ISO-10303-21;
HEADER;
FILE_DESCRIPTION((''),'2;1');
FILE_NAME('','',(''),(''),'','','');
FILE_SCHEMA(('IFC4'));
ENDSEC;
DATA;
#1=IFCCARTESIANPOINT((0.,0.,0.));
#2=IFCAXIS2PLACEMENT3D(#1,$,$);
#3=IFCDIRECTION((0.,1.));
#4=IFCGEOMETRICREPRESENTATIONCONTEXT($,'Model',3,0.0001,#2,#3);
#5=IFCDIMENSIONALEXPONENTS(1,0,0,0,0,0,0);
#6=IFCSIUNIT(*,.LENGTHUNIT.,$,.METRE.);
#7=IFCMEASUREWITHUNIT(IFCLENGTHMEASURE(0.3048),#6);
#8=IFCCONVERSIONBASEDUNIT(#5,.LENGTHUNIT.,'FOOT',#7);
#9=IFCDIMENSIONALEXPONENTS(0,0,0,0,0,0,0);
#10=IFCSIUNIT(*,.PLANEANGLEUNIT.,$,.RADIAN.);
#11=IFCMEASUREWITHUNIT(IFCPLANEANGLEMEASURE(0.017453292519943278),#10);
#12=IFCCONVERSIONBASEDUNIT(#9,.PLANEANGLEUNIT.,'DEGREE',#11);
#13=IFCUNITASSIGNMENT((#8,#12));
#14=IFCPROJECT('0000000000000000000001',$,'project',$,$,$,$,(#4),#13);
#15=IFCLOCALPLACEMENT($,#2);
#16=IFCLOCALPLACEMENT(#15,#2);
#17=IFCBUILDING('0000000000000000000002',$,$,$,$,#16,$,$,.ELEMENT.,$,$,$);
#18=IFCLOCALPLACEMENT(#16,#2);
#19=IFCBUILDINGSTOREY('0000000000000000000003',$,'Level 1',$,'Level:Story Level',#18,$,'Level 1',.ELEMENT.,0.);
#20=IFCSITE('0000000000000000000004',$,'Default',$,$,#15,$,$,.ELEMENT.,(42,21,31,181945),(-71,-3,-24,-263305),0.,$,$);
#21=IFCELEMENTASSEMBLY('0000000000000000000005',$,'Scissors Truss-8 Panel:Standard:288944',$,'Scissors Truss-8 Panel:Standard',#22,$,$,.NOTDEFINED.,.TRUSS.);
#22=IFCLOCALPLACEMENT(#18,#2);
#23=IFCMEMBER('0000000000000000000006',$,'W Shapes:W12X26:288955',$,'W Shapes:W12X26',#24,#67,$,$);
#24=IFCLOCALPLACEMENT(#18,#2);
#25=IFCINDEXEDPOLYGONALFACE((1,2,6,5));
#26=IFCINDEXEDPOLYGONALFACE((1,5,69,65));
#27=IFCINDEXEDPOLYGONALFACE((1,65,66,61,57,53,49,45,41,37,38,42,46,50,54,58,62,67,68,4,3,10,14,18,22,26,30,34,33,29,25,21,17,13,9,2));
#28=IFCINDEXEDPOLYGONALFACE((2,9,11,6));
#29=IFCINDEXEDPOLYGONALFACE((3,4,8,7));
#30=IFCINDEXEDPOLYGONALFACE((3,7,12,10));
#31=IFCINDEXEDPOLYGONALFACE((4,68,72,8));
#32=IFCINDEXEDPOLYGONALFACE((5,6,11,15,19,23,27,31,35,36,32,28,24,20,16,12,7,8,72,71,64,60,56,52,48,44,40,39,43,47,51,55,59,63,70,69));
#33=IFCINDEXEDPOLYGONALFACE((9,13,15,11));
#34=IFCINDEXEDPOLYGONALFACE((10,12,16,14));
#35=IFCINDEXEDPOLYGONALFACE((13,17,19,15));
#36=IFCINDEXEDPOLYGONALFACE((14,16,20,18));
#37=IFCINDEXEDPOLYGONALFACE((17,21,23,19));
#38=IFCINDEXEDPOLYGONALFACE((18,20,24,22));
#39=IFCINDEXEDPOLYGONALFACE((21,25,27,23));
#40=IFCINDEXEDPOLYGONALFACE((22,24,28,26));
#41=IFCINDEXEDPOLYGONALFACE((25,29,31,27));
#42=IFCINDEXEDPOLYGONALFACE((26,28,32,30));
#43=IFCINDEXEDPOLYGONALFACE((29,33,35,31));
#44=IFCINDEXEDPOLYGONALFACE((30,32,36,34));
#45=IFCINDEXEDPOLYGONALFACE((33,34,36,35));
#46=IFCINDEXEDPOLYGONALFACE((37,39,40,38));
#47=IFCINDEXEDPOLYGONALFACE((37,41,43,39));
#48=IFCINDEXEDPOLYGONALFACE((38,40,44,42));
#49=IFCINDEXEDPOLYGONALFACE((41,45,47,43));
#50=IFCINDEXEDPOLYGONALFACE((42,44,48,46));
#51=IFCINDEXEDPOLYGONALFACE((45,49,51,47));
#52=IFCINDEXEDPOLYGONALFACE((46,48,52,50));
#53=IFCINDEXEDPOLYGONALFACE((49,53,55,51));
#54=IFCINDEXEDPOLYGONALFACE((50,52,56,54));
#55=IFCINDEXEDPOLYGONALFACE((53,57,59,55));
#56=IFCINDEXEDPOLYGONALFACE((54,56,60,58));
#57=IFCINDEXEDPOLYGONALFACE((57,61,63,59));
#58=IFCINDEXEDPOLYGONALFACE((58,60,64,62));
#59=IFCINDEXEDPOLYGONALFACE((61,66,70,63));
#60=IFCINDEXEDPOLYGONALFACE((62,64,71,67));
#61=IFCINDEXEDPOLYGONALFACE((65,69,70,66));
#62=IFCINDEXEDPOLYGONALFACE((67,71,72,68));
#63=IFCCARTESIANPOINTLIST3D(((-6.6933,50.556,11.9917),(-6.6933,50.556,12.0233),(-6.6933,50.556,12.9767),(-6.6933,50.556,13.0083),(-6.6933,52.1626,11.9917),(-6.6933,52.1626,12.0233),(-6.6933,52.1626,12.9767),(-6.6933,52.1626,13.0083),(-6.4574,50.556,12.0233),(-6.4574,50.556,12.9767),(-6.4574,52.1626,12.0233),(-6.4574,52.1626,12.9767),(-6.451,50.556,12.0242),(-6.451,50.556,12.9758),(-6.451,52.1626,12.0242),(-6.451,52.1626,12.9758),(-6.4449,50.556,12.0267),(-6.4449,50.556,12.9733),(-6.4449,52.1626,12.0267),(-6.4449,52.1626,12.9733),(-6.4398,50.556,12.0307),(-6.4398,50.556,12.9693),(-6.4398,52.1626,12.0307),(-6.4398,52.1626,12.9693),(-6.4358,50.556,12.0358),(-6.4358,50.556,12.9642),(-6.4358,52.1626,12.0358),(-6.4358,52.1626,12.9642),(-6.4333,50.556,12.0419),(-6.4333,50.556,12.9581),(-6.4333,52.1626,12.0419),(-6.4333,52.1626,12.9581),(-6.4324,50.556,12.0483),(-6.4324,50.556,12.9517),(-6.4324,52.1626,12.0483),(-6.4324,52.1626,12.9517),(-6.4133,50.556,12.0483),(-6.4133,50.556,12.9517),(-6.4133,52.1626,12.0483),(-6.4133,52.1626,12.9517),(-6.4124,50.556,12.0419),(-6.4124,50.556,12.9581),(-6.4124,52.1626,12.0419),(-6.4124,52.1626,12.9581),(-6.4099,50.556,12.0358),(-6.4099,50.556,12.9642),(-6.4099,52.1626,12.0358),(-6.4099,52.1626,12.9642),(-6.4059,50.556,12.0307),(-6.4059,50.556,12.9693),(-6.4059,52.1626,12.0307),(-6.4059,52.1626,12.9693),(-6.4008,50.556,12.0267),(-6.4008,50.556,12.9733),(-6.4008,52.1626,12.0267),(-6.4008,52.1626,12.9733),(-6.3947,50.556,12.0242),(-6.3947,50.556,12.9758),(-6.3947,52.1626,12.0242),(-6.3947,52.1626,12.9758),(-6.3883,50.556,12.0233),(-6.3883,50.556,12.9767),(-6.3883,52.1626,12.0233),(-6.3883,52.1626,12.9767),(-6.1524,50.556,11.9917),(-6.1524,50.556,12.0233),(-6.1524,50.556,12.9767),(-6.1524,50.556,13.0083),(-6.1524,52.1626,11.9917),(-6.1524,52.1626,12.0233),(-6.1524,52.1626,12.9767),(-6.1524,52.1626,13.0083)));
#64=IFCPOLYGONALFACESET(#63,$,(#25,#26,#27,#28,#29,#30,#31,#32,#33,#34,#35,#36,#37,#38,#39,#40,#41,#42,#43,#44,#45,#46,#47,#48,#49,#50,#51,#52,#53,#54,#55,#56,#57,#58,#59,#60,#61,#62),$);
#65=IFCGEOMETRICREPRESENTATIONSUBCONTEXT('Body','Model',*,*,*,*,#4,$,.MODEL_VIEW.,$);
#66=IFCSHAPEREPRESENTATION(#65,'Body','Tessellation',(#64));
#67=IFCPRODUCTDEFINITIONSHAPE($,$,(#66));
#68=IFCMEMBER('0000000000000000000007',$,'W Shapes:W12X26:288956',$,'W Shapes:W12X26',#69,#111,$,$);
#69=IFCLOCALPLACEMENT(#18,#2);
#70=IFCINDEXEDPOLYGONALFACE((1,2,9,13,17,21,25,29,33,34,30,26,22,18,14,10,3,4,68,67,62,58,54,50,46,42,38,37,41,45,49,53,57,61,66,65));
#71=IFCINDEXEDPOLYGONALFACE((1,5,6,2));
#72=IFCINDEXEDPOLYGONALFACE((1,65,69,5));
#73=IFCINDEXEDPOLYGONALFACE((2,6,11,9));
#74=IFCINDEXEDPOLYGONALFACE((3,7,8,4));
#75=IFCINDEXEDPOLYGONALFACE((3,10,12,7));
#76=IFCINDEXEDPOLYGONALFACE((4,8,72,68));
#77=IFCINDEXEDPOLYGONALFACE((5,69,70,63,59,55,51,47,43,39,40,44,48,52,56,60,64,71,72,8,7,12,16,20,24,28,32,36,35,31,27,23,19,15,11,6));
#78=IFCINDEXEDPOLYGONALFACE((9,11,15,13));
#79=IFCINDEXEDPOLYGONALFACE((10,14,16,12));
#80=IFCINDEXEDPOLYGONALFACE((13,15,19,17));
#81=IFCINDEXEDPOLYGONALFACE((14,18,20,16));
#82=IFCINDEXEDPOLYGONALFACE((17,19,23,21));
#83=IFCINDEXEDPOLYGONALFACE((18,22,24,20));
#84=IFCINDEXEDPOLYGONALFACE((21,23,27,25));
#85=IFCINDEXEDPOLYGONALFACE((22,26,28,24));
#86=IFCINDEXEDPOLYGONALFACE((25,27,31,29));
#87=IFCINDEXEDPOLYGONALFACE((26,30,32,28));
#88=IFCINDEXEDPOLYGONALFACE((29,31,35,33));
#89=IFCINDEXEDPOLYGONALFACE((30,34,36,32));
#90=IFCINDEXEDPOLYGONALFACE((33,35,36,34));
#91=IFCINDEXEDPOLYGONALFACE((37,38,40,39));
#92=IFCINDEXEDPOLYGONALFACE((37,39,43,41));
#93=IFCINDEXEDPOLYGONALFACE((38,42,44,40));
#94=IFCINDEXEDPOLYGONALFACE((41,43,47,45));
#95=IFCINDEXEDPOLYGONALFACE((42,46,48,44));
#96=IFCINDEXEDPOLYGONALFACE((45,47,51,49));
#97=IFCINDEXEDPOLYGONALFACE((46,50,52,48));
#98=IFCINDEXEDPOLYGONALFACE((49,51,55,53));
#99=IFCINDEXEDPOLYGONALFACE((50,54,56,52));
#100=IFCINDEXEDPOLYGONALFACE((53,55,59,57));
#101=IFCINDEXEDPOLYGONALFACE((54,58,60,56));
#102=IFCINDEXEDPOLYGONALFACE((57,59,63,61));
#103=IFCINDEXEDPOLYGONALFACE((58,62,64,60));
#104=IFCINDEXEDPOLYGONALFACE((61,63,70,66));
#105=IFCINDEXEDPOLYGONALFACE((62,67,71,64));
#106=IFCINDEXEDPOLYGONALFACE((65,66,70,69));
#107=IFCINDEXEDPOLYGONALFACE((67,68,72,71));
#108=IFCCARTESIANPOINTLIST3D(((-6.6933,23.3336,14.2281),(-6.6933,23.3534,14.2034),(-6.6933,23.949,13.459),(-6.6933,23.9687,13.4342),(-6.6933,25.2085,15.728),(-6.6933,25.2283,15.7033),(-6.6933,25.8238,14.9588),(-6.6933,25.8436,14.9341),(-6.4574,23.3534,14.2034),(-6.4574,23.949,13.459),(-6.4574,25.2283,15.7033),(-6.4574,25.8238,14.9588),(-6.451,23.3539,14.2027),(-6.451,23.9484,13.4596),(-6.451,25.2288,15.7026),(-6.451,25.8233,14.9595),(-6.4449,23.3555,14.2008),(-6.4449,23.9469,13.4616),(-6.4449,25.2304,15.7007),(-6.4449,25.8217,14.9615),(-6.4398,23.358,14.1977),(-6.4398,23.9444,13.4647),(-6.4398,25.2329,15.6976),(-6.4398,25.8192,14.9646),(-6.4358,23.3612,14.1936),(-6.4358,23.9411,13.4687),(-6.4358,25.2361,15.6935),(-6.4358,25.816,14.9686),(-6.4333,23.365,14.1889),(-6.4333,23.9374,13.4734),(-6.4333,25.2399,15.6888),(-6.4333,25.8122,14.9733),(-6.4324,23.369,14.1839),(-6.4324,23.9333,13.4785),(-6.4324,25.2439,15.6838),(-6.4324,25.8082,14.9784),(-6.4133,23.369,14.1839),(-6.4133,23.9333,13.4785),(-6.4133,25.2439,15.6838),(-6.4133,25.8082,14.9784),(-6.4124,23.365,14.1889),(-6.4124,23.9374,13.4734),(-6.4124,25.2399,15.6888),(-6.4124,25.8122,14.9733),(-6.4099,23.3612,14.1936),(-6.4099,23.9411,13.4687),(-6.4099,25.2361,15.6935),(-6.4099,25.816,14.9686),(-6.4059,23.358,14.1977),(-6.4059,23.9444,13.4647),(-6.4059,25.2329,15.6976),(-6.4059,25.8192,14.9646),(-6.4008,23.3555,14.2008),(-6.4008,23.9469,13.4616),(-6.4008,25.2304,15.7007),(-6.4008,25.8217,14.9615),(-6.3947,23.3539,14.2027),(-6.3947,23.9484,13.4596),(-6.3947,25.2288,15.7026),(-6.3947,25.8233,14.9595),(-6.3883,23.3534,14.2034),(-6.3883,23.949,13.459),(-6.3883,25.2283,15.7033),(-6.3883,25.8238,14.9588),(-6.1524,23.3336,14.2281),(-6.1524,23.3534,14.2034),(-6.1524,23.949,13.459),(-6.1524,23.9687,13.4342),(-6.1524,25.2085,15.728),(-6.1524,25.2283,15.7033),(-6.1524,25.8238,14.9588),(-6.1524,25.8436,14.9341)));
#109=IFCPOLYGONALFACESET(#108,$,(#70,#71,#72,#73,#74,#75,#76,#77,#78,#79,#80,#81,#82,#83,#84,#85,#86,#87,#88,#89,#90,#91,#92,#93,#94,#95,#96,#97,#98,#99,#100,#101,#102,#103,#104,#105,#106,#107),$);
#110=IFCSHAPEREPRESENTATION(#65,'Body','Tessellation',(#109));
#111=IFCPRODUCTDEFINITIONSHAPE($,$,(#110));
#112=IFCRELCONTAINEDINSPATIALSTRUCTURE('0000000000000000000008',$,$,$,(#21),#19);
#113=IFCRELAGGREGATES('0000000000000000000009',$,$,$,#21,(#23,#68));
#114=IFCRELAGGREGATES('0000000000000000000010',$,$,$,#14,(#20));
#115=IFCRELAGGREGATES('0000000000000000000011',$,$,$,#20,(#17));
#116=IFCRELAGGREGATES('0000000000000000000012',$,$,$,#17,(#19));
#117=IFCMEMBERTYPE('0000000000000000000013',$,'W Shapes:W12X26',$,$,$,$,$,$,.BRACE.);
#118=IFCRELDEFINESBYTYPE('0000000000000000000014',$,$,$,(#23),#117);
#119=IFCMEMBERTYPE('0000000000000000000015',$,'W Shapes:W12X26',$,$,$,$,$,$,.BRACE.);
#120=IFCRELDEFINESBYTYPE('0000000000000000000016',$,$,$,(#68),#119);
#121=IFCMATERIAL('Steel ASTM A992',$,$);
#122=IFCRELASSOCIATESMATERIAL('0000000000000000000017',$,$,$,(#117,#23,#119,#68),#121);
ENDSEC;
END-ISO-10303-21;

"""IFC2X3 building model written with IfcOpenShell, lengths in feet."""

from ifc_helpers import new_model, entity, si_unit, converted_unit, direction, frame, frame_2d, origin, place, context, subcontext, project, spatial, polyline, circle_curve, parameter, trimmed, segment, composite_curve, outline, extrude, source, transform, mapped, material, type_object, type_shapes, element, aggregate, save


model = new_model("IFC2X3")

# Units and contexts
model_context = context("Model", 3, precision=0.0001, world=origin(), true_north=direction((0.0, 1.0)))
body_context = subcontext(model_context, "Body", "Model", "MODEL_VIEW")
ifc_project = project(units=[converted_unit("LENGTHUNIT", "FOOT", entity("IfcLengthMeasure", 0.3048), si_unit("LENGTHUNIT", "METRE"), dimensions=[1, 0, 0, 0, 0, 0, 0]), converted_unit("PLANEANGLEUNIT", "DEGREE", entity("IfcPlaneAngleMeasure", 0.017453292519943278), si_unit("PLANEANGLEUNIT", "RADIAN"), dimensions=[0, 0, 0, 0, 0, 0, 0])], contexts=[model_context])

# Site, building, storey
site_placement = place(None, origin())
site = spatial("IfcSite", under=ifc_project, at=site_placement, Name="Default", CompositionType="ELEMENT", RefLatitude=(42, 21, 31, 181945), RefLongitude=(-71, -3, -24, -263305), RefElevation=0.0)
building_placement = place(site_placement, origin())
building = spatial("IfcBuilding", under=site, at=building_placement, CompositionType="ELEMENT")
storey_placement = place(building_placement, origin())
storey = spatial("IfcBuildingStorey", under=building, at=storey_placement, Name="Level 1", ObjectType="Level:Story Level", LongName="Level 1", CompositionType="ELEMENT", Elevation=0.0)

# Element assembly, members
assembly_placement = place(storey_placement, origin())
assembly = element("IfcElementAssembly", 1, at=assembly_placement, inside=storey, Name="Scissors Truss-8 Panel:Standard:288944", ObjectType="Scissors Truss-8 Panel:Standard", AssemblyPlace="NOTDEFINED", PredefinedType="TRUSS")
ifc_material = material(Name="Steel ASTM A992")
member_type_1 = type_object("IfcMemberType", Name="W Shapes:W12X26", PredefinedType="BRACE", material=ifc_material)
shared_shape_1 = source(origin(), body_context, "Body", "SweptSolid", [
    extrude(outline(composite_curve([segment(polyline([(0.4767, -0.2704), (0.5083, -0.2704)]), True, "CONTINUOUS"), segment(polyline([(0.5083, -0.2704), (0.5083, 0.2704)]), True, "CONTINUOUS"), segment(polyline([(0.5083, 0.2704), (0.4767, 0.2704)]), True, "CONTINUOUS"), segment(polyline([(0.4767, 0.2704), (0.4767, 0.0346)]), True, "CONTINUOUS"), segment(trimmed(circle_curve(frame_2d((0.4517, 0.0346), x_axis=(0.0, 1.0)), 0.025), [parameter(180.0)], [parameter(270.0)], True, "PARAMETER"), False, "CONTINUOUS"), segment(polyline([(0.4517, 0.0096), (-0.4517, 0.0096)]), True, "CONTINUOUS"), segment(trimmed(circle_curve(frame_2d((-0.4517, 0.0346), x_axis=(0.0, 1.0)), 0.025), [parameter(90.0)], [parameter(180.0)], True, "PARAMETER"), False, "CONTINUOUS"), segment(polyline([(-0.4767, 0.0346), (-0.4767, 0.2704)]), True, "CONTINUOUS"), segment(polyline([(-0.4767, 0.2704), (-0.5083, 0.2704)]), True, "CONTINUOUS"), segment(polyline([(-0.5083, 0.2704), (-0.5083, -0.2704)]), True, "CONTINUOUS"), segment(polyline([(-0.5083, -0.2704), (-0.4767, -0.2704)]), True, "CONTINUOUS"), segment(polyline([(-0.4767, -0.2704), (-0.4767, -0.0346)]), True, "CONTINUOUS"), segment(trimmed(circle_curve(frame_2d((-0.4517, -0.0346), x_axis=(0.0, 1.0)), 0.025), [parameter(360.0)], [parameter(90.0)], True, "PARAMETER"), False, "CONTINUOUS"), segment(polyline([(-0.4517, -0.0096), (0.4517, -0.0096)]), True, "CONTINUOUS"), segment(trimmed(circle_curve(frame_2d((0.4517, -0.0346), x_axis=(0.0, 1.0)), 0.025), [parameter(270.0)], [parameter(360.0)], True, "PARAMETER"), False, "CONTINUOUS"), segment(polyline([(0.4767, -0.0346), (0.4767, -0.2704)]), True, "CONTINUOUS")], self_intersect=False)), frame((0.4438, 0.0, 0.0), z_axis=(1.0, 0.0, 0.0), x_axis=(0.0, 0.0, -1.0)), (0.0, 0.0, 1.0), 1.6066),
])
type_shapes(member_type_1, [shared_shape_1])
member_1_placement = place(assembly_placement, frame((-6.4228, 50.1122, 12.5), z_axis=(0.0, 0.0, -1.0), x_axis=(0.0, 1.0, 0.0)))
member_1 = element("IfcMember", 2, at=member_1_placement, type_object=member_type_1, material=ifc_material, Name="W Shapes:W12X26:288955", ObjectType="W Shapes:W12X26", context=body_context, shape_type="MappedRepresentation", body=[
    mapped(shared_shape_1, transform((0.0, 0.0, 0.0), scale=1.0)),
])
member_type_2 = type_object("IfcMemberType", Name="W Shapes:W12X26", PredefinedType="BRACE", material=ifc_material)
shared_shape_2 = source(origin(), body_context, "Body", "SweptSolid", [
    extrude(outline(composite_curve([segment(polyline([(-0.2704, -0.4767), (-0.2704, -0.5083)]), True, "CONTINUOUS"), segment(polyline([(-0.2704, -0.5083), (0.2704, -0.5083)]), True, "CONTINUOUS"), segment(polyline([(0.2704, -0.5083), (0.2704, -0.4767)]), True, "CONTINUOUS"), segment(polyline([(0.2704, -0.4767), (0.0346, -0.4767)]), True, "CONTINUOUS"), segment(trimmed(circle_curve(frame_2d((0.0346, -0.4517), x_axis=(1.0, 0.0)), 0.025), [parameter(180.0)], [parameter(270.0)], True, "PARAMETER"), False, "CONTINUOUS"), segment(polyline([(0.0096, -0.4517), (0.0096, 0.4517)]), True, "CONTINUOUS"), segment(trimmed(circle_curve(frame_2d((0.0346, 0.4517), x_axis=(1.0, 0.0)), 0.025), [parameter(90.0)], [parameter(180.0)], True, "PARAMETER"), False, "CONTINUOUS"), segment(polyline([(0.0346, 0.4767), (0.2704, 0.4767)]), True, "CONTINUOUS"), segment(polyline([(0.2704, 0.4767), (0.2704, 0.5083)]), True, "CONTINUOUS"), segment(polyline([(0.2704, 0.5083), (-0.2704, 0.5083)]), True, "CONTINUOUS"), segment(polyline([(-0.2704, 0.5083), (-0.2704, 0.4767)]), True, "CONTINUOUS"), segment(polyline([(-0.2704, 0.4767), (-0.0346, 0.4767)]), True, "CONTINUOUS"), segment(trimmed(circle_curve(frame_2d((-0.0346, 0.4517), x_axis=(1.0, 0.0)), 0.025), [parameter(360.0)], [parameter(90.0)], True, "PARAMETER"), False, "CONTINUOUS"), segment(polyline([(-0.0096, 0.4517), (-0.0096, -0.4517)]), True, "CONTINUOUS"), segment(trimmed(circle_curve(frame_2d((-0.0346, -0.4517), x_axis=(1.0, 0.0)), 0.025), [parameter(270.0)], [parameter(360.0)], True, "PARAMETER"), False, "CONTINUOUS"), segment(polyline([(-0.0346, -0.4767), (-0.2704, -0.4767)]), True, "CONTINUOUS")], self_intersect=False)), frame((-1.871, 0.0, 0.0), z_axis=(-1.0, 0.0, 0.0), x_axis=(0.0, -1.0, 0.0)), (0.0, 0.0, -1.0), 2.401),
])
type_shapes(member_type_2, [shared_shape_2])
member_2_placement = place(assembly_placement, frame((-6.4228, 25.1122, 15.0), z_axis=(0.0, 0.624695, -0.780869), x_axis=(0.0, 0.780869, 0.624695)))
member_2 = element("IfcMember", 3, at=member_2_placement, type_object=member_type_2, material=ifc_material, Name="W Shapes:W12X26:288956", ObjectType="W Shapes:W12X26", context=body_context, shape_type="MappedRepresentation", body=[
    mapped(shared_shape_2, transform((0.0, 0.0, 0.0), scale=1.0)),
])
aggregate(assembly, [member_1, member_2])

save(model, "model.ifc")
